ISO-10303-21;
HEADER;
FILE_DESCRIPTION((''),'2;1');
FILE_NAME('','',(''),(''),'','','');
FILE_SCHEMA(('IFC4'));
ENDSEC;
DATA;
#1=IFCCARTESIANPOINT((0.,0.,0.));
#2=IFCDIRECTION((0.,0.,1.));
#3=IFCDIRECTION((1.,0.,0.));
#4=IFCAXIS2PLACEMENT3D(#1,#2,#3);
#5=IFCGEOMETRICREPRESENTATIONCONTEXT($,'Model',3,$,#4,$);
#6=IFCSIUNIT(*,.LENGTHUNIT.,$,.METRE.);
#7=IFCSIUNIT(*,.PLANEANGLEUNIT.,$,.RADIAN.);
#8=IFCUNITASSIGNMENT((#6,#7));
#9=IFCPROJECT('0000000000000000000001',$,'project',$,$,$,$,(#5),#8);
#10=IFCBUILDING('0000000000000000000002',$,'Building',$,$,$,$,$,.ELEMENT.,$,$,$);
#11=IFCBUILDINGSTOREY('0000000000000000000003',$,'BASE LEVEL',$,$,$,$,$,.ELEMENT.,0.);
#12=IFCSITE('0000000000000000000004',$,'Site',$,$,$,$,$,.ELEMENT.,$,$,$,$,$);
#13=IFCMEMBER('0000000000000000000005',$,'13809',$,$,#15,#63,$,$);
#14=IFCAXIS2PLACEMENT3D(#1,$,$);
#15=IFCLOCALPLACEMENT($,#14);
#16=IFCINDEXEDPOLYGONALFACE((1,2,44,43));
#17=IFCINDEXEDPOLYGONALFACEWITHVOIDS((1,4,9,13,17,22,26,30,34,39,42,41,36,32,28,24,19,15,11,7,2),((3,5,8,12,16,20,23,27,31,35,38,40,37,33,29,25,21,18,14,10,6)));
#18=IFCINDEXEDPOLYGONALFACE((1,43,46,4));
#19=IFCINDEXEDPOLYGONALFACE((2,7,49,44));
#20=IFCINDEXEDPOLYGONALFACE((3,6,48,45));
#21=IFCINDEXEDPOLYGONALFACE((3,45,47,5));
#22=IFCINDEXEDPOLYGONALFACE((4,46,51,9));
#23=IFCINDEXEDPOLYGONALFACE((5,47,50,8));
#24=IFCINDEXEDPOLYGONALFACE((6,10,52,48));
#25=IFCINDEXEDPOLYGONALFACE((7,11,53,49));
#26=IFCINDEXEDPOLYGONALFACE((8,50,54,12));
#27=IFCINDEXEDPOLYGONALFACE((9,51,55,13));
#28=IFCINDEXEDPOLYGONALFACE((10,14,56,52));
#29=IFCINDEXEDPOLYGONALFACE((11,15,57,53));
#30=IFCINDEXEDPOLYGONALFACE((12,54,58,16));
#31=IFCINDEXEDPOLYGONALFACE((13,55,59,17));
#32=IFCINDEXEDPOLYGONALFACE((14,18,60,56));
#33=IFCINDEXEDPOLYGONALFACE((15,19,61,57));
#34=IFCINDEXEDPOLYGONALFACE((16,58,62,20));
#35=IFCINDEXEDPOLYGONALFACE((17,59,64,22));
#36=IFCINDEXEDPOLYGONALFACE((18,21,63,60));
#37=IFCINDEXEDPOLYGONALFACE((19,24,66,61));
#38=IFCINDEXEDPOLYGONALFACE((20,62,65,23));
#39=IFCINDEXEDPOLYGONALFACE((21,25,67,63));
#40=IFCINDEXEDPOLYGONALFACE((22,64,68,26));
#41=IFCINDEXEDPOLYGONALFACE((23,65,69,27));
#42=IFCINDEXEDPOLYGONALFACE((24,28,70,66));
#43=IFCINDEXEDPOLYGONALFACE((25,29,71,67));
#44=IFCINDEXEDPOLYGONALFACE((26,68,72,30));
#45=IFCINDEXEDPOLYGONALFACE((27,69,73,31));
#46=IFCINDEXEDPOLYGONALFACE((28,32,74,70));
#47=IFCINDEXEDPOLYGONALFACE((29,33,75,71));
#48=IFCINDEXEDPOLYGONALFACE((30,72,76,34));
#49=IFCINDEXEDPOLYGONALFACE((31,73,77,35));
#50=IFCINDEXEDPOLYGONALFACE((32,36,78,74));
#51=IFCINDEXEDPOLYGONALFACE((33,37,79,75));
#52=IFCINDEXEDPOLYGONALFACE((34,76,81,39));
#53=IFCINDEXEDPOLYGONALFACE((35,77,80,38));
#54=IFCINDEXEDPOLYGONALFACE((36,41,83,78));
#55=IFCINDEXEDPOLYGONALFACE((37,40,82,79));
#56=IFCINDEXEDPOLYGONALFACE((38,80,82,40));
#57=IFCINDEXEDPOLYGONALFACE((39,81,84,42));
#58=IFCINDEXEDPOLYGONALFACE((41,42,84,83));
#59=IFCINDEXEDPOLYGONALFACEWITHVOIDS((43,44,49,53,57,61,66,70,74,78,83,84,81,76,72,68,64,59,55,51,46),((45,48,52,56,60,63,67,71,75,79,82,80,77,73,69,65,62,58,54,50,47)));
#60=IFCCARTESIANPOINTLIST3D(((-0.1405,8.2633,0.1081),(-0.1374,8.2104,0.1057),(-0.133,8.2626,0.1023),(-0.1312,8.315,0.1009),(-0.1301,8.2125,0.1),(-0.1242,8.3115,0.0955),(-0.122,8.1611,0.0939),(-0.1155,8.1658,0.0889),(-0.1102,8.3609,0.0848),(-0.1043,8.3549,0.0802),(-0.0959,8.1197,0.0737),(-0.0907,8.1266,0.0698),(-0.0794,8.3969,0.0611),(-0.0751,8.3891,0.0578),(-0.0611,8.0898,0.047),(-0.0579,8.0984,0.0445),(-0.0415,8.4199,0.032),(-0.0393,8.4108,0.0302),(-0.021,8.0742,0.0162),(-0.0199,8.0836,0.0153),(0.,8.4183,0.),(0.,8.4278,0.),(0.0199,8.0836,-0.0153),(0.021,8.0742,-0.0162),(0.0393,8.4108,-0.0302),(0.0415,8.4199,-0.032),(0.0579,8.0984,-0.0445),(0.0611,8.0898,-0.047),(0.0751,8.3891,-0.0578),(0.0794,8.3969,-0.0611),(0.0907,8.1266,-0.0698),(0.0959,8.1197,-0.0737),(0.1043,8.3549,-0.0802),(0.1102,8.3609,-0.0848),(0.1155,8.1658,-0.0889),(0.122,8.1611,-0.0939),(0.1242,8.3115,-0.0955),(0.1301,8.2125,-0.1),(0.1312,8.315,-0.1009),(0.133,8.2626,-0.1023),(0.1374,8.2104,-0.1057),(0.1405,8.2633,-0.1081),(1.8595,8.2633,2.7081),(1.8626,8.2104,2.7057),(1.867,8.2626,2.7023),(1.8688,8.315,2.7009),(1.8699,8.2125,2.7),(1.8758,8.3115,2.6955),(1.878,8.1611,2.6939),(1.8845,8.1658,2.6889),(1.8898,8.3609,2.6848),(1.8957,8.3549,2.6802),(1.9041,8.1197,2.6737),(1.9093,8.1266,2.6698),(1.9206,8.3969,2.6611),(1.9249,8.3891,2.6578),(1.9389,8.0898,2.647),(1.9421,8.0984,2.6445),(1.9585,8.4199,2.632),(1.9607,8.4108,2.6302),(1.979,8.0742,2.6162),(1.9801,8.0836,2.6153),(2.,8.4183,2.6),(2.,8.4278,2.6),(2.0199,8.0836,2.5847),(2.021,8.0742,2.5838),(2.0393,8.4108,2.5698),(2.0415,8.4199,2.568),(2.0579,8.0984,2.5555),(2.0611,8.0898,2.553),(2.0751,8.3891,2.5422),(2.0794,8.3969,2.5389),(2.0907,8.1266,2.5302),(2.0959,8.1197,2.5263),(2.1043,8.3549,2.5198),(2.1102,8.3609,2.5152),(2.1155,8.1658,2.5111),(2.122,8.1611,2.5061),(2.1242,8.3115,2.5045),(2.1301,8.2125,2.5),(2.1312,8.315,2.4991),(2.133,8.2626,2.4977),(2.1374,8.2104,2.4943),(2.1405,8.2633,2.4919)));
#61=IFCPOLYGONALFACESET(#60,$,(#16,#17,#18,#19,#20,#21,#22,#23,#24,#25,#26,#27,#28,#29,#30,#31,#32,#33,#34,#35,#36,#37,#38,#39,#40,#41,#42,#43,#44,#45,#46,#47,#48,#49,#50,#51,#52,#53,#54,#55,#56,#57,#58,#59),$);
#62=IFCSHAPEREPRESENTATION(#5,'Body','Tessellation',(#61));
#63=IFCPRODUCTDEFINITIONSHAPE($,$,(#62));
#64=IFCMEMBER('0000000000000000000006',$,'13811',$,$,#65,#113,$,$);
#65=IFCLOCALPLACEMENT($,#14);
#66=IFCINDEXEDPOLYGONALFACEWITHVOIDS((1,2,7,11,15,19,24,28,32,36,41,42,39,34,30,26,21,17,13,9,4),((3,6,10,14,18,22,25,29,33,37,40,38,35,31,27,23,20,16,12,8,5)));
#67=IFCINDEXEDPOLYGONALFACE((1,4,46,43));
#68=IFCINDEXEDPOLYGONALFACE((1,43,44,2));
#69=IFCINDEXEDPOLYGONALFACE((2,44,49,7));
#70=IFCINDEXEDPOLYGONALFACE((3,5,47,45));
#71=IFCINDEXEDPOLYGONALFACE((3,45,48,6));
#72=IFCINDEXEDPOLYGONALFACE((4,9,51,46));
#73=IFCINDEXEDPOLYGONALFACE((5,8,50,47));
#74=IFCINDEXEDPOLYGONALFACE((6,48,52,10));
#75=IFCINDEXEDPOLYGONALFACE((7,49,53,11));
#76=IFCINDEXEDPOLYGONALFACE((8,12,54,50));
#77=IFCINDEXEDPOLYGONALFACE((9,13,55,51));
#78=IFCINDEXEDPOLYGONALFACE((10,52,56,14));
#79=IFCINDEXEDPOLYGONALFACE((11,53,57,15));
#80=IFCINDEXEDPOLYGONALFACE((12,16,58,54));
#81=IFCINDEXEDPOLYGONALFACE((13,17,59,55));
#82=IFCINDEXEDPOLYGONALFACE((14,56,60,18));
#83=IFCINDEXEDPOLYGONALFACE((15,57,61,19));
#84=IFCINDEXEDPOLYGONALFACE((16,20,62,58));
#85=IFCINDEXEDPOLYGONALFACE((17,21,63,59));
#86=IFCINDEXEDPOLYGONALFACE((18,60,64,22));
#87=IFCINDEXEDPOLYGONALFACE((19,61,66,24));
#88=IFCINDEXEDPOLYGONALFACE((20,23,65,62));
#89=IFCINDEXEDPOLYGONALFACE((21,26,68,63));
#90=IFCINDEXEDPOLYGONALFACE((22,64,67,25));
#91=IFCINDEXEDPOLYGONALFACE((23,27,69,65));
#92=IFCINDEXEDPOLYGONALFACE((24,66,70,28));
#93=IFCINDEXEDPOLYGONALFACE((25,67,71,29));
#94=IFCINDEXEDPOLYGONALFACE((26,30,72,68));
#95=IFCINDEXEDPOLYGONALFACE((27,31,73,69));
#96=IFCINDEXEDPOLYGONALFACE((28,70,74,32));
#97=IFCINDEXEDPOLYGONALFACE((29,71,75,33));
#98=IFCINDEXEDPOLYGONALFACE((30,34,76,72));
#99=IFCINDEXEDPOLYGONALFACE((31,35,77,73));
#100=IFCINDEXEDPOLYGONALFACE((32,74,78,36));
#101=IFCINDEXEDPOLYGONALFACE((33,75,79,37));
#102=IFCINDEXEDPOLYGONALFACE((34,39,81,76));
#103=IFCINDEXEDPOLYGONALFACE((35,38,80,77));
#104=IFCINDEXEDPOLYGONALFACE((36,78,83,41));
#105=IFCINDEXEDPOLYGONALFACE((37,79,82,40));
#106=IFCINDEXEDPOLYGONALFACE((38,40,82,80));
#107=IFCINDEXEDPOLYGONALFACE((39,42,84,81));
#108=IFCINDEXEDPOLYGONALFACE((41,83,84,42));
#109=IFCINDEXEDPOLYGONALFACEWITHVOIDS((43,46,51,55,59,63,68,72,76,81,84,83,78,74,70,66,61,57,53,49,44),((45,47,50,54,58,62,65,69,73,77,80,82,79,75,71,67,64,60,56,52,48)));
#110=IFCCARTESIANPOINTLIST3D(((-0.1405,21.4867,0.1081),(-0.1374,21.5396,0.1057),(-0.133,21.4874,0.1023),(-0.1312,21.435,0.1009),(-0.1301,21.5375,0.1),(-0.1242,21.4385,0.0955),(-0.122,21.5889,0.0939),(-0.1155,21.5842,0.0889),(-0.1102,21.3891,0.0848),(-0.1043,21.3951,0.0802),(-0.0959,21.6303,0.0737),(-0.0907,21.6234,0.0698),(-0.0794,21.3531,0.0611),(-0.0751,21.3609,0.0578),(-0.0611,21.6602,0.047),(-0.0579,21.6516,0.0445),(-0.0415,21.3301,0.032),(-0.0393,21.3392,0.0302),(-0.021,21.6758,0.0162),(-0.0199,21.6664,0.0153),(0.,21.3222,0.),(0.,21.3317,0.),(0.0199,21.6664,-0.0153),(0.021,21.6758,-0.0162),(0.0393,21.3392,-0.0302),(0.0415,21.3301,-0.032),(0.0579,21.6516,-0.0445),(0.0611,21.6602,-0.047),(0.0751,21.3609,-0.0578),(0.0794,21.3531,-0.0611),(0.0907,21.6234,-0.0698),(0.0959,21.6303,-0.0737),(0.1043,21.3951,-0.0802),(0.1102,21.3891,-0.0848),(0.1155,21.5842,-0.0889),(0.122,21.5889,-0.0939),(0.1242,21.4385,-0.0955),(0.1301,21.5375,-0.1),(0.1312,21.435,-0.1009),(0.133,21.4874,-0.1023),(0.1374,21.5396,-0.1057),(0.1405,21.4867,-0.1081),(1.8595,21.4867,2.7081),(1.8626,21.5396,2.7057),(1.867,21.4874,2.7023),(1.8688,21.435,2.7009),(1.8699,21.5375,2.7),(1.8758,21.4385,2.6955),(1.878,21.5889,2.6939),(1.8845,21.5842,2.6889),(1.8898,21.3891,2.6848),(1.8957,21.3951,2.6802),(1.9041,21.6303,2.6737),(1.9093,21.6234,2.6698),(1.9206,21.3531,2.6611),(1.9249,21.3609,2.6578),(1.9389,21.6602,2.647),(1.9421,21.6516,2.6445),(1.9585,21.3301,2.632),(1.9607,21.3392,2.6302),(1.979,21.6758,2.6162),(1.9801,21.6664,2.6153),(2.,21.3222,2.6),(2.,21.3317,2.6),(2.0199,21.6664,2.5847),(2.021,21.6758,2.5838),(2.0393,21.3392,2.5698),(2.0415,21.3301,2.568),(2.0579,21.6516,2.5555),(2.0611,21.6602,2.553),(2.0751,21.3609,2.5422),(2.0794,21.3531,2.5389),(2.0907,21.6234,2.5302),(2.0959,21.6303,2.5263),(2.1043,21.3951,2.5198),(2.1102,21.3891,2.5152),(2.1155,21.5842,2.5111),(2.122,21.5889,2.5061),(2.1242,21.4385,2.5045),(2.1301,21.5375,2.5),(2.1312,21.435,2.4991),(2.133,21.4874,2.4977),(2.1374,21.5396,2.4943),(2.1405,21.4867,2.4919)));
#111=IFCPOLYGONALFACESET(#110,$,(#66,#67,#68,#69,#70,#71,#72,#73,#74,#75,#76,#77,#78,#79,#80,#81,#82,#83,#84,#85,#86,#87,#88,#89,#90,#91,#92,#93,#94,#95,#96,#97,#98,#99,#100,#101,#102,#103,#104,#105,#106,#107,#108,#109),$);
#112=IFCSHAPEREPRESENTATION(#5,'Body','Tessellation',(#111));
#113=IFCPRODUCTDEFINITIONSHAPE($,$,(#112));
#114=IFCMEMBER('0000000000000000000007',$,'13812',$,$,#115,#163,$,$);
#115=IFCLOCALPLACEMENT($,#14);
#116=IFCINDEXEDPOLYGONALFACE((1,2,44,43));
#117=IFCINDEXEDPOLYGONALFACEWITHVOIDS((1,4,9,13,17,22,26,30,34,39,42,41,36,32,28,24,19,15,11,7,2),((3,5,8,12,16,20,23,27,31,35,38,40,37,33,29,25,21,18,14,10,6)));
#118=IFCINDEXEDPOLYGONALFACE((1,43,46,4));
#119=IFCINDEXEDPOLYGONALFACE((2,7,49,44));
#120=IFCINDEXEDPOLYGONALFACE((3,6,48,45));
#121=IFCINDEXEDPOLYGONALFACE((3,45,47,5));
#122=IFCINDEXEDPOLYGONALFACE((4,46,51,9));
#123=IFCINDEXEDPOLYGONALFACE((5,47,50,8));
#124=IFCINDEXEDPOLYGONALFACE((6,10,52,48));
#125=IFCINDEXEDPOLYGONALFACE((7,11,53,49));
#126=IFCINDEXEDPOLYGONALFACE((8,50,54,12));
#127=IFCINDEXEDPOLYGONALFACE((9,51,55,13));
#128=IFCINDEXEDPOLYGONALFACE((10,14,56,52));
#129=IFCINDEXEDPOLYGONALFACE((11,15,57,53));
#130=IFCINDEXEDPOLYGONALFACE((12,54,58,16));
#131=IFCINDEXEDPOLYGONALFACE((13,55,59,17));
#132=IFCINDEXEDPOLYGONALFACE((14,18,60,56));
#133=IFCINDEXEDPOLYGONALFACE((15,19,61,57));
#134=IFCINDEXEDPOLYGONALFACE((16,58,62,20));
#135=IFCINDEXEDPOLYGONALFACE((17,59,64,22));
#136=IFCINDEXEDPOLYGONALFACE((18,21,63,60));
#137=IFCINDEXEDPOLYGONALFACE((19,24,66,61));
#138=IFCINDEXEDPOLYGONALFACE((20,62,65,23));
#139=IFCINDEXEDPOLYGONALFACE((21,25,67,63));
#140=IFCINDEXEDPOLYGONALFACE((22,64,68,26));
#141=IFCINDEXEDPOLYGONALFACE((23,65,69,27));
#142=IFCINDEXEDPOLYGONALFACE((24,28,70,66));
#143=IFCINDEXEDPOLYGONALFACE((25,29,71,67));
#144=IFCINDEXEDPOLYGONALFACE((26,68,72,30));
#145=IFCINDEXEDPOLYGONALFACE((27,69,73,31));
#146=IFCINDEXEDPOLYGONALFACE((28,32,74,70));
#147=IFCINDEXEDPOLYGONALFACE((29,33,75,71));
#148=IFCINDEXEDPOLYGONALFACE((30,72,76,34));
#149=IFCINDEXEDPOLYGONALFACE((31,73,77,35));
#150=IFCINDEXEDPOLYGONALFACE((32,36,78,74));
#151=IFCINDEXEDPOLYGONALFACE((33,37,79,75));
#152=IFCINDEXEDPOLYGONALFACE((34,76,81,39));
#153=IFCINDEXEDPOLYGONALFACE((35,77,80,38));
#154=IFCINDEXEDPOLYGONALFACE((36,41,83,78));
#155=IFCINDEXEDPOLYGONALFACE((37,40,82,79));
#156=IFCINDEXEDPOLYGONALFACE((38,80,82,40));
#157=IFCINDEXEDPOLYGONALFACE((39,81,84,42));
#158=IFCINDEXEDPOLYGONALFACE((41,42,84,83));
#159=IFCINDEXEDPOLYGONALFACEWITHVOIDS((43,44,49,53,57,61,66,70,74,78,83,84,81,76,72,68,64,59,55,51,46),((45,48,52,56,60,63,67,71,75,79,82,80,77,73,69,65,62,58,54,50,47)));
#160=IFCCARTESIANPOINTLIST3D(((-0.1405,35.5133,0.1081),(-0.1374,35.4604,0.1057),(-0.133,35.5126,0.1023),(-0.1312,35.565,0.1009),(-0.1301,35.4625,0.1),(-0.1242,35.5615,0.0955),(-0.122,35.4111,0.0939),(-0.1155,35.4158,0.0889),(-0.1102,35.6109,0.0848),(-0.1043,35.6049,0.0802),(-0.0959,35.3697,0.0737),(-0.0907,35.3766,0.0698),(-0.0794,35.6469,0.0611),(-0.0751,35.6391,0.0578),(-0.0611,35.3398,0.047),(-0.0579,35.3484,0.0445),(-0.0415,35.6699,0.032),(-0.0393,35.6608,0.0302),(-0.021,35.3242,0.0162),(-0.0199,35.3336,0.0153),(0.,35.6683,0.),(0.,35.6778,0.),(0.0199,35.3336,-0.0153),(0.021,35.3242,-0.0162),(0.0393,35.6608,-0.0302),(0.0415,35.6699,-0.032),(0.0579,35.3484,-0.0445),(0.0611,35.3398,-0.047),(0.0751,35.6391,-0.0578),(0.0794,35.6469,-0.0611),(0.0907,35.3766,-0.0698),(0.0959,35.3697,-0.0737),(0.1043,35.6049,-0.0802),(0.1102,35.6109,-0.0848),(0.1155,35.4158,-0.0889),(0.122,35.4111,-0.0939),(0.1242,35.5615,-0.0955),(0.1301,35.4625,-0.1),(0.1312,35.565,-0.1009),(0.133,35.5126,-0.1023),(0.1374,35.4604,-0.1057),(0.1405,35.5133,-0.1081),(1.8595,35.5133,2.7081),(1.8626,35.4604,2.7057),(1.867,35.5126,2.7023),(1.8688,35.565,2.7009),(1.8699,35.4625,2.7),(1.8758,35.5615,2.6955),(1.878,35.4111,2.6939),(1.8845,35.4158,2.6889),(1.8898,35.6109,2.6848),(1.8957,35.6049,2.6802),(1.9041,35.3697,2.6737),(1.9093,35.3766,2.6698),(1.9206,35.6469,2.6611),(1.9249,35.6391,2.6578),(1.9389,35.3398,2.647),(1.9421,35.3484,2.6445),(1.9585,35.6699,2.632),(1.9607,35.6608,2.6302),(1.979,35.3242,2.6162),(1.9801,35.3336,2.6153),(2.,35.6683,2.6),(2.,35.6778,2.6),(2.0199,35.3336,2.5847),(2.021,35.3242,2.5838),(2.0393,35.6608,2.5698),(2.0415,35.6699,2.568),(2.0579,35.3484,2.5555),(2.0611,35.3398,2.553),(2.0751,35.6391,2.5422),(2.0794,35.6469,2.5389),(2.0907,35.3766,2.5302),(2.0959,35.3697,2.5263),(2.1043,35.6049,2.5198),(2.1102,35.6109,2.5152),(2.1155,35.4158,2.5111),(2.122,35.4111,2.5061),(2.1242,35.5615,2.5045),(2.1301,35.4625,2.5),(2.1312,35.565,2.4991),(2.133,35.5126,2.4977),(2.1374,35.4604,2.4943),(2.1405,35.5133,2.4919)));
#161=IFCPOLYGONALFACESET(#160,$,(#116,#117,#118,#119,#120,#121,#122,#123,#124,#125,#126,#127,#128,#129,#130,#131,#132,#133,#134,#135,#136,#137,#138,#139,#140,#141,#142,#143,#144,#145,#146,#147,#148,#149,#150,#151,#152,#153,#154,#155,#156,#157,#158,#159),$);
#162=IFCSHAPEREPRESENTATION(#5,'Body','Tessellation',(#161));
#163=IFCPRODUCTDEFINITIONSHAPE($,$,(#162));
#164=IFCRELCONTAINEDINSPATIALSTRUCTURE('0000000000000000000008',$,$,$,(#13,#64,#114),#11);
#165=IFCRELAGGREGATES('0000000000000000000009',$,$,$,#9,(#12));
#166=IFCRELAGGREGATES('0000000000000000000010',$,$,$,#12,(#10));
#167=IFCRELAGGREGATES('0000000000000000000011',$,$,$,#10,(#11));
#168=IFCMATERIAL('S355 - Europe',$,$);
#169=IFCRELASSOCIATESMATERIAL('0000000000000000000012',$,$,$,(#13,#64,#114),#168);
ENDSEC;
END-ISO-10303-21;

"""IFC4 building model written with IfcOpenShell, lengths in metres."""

from ifc_helpers import new_model, si_unit, frame, origin_with_axes, origin_2d_with_axis, place, context, project, spatial, hollow_circle, extrude, material, material_profile, profile_set, profile_usage, element, save


model = new_model("IFC4")

# Units and contexts
model_context = context("Model", 3, world=origin_with_axes())
ifc_project = project(units=[si_unit("LENGTHUNIT", "METRE"), si_unit("PLANEANGLEUNIT", "RADIAN")], contexts=[model_context])

# Site, building, storey
site = spatial("IfcSite", under=ifc_project, Name="Site", CompositionType="ELEMENT")
building = spatial("IfcBuilding", under=site, Name="Building", CompositionType="ELEMENT")
storey = spatial("IfcBuildingStorey", under=building, Name="BASE LEVEL", CompositionType="ELEMENT", Elevation=0.0)

# Shared definitions
ifc_material = material(Name="S355 - Europe")

# Members
ifc_material_profile_1 = material_profile(ifc_material, hollow_circle(Radius=0.1778, WallThickness=0.0095, at=origin_2d_with_axis()))
ifc_profile_set_1 = profile_set([ifc_material_profile_1])
ifc_profile_usage_1 = profile_usage(ifc_profile_set_1, cardinal=10)
member_1_placement = place(None, frame((0.0, 8.25, 0.0), z_axis=(0.609711, 0.0, 0.792624), x_axis=(0.0, 1.0, 0.0)))
element("IfcMember", 1, at=member_1_placement, inside=storey, material=ifc_profile_usage_1, Name="13809", context=model_context, shape_type="SweptSolid", body=[
    extrude(hollow_circle(Radius=0.1778, WallThickness=0.0095, at=origin_2d_with_axis()), origin_with_axes(), (0.0, 0.0, 1.0), 3.2802),
])
ifc_material_profile_2 = material_profile(ifc_material, hollow_circle(Radius=0.1778, WallThickness=0.0095, at=origin_2d_with_axis()))
ifc_profile_set_2 = profile_set([ifc_material_profile_2])
ifc_profile_usage_2 = profile_usage(ifc_profile_set_2, cardinal=10)
member_2_placement = place(None, frame((2.0, 21.5, 2.6), z_axis=(-0.609711, 0.0, -0.792624), x_axis=(0.0, -1.0, 0.0)))
element("IfcMember", 2, at=member_2_placement, inside=storey, material=ifc_profile_usage_2, Name="13811", context=model_context, shape_type="SweptSolid", body=[
    extrude(hollow_circle(Radius=0.1778, WallThickness=0.0095, at=origin_2d_with_axis()), origin_with_axes(), (0.0, 0.0, 1.0), 3.2802),
])
ifc_material_profile_3 = material_profile(ifc_material, hollow_circle(Radius=0.1778, WallThickness=0.0095, at=origin_2d_with_axis()))
ifc_profile_set_3 = profile_set([ifc_material_profile_3])
ifc_profile_usage_3 = profile_usage(ifc_profile_set_3, cardinal=10)
member_3_placement = place(None, frame((0.0, 35.5, 0.0), z_axis=(0.609711, 0.0, 0.792624), x_axis=(0.0, 1.0, 0.0)))
element("IfcMember", 3, at=member_3_placement, inside=storey, material=ifc_profile_usage_3, Name="13812", context=model_context, shape_type="SweptSolid", body=[
    extrude(hollow_circle(Radius=0.1778, WallThickness=0.0095, at=origin_2d_with_axis()), origin_with_axes(), (0.0, 0.0, 1.0), 3.2802),
])

save(model, "model.ifc")
